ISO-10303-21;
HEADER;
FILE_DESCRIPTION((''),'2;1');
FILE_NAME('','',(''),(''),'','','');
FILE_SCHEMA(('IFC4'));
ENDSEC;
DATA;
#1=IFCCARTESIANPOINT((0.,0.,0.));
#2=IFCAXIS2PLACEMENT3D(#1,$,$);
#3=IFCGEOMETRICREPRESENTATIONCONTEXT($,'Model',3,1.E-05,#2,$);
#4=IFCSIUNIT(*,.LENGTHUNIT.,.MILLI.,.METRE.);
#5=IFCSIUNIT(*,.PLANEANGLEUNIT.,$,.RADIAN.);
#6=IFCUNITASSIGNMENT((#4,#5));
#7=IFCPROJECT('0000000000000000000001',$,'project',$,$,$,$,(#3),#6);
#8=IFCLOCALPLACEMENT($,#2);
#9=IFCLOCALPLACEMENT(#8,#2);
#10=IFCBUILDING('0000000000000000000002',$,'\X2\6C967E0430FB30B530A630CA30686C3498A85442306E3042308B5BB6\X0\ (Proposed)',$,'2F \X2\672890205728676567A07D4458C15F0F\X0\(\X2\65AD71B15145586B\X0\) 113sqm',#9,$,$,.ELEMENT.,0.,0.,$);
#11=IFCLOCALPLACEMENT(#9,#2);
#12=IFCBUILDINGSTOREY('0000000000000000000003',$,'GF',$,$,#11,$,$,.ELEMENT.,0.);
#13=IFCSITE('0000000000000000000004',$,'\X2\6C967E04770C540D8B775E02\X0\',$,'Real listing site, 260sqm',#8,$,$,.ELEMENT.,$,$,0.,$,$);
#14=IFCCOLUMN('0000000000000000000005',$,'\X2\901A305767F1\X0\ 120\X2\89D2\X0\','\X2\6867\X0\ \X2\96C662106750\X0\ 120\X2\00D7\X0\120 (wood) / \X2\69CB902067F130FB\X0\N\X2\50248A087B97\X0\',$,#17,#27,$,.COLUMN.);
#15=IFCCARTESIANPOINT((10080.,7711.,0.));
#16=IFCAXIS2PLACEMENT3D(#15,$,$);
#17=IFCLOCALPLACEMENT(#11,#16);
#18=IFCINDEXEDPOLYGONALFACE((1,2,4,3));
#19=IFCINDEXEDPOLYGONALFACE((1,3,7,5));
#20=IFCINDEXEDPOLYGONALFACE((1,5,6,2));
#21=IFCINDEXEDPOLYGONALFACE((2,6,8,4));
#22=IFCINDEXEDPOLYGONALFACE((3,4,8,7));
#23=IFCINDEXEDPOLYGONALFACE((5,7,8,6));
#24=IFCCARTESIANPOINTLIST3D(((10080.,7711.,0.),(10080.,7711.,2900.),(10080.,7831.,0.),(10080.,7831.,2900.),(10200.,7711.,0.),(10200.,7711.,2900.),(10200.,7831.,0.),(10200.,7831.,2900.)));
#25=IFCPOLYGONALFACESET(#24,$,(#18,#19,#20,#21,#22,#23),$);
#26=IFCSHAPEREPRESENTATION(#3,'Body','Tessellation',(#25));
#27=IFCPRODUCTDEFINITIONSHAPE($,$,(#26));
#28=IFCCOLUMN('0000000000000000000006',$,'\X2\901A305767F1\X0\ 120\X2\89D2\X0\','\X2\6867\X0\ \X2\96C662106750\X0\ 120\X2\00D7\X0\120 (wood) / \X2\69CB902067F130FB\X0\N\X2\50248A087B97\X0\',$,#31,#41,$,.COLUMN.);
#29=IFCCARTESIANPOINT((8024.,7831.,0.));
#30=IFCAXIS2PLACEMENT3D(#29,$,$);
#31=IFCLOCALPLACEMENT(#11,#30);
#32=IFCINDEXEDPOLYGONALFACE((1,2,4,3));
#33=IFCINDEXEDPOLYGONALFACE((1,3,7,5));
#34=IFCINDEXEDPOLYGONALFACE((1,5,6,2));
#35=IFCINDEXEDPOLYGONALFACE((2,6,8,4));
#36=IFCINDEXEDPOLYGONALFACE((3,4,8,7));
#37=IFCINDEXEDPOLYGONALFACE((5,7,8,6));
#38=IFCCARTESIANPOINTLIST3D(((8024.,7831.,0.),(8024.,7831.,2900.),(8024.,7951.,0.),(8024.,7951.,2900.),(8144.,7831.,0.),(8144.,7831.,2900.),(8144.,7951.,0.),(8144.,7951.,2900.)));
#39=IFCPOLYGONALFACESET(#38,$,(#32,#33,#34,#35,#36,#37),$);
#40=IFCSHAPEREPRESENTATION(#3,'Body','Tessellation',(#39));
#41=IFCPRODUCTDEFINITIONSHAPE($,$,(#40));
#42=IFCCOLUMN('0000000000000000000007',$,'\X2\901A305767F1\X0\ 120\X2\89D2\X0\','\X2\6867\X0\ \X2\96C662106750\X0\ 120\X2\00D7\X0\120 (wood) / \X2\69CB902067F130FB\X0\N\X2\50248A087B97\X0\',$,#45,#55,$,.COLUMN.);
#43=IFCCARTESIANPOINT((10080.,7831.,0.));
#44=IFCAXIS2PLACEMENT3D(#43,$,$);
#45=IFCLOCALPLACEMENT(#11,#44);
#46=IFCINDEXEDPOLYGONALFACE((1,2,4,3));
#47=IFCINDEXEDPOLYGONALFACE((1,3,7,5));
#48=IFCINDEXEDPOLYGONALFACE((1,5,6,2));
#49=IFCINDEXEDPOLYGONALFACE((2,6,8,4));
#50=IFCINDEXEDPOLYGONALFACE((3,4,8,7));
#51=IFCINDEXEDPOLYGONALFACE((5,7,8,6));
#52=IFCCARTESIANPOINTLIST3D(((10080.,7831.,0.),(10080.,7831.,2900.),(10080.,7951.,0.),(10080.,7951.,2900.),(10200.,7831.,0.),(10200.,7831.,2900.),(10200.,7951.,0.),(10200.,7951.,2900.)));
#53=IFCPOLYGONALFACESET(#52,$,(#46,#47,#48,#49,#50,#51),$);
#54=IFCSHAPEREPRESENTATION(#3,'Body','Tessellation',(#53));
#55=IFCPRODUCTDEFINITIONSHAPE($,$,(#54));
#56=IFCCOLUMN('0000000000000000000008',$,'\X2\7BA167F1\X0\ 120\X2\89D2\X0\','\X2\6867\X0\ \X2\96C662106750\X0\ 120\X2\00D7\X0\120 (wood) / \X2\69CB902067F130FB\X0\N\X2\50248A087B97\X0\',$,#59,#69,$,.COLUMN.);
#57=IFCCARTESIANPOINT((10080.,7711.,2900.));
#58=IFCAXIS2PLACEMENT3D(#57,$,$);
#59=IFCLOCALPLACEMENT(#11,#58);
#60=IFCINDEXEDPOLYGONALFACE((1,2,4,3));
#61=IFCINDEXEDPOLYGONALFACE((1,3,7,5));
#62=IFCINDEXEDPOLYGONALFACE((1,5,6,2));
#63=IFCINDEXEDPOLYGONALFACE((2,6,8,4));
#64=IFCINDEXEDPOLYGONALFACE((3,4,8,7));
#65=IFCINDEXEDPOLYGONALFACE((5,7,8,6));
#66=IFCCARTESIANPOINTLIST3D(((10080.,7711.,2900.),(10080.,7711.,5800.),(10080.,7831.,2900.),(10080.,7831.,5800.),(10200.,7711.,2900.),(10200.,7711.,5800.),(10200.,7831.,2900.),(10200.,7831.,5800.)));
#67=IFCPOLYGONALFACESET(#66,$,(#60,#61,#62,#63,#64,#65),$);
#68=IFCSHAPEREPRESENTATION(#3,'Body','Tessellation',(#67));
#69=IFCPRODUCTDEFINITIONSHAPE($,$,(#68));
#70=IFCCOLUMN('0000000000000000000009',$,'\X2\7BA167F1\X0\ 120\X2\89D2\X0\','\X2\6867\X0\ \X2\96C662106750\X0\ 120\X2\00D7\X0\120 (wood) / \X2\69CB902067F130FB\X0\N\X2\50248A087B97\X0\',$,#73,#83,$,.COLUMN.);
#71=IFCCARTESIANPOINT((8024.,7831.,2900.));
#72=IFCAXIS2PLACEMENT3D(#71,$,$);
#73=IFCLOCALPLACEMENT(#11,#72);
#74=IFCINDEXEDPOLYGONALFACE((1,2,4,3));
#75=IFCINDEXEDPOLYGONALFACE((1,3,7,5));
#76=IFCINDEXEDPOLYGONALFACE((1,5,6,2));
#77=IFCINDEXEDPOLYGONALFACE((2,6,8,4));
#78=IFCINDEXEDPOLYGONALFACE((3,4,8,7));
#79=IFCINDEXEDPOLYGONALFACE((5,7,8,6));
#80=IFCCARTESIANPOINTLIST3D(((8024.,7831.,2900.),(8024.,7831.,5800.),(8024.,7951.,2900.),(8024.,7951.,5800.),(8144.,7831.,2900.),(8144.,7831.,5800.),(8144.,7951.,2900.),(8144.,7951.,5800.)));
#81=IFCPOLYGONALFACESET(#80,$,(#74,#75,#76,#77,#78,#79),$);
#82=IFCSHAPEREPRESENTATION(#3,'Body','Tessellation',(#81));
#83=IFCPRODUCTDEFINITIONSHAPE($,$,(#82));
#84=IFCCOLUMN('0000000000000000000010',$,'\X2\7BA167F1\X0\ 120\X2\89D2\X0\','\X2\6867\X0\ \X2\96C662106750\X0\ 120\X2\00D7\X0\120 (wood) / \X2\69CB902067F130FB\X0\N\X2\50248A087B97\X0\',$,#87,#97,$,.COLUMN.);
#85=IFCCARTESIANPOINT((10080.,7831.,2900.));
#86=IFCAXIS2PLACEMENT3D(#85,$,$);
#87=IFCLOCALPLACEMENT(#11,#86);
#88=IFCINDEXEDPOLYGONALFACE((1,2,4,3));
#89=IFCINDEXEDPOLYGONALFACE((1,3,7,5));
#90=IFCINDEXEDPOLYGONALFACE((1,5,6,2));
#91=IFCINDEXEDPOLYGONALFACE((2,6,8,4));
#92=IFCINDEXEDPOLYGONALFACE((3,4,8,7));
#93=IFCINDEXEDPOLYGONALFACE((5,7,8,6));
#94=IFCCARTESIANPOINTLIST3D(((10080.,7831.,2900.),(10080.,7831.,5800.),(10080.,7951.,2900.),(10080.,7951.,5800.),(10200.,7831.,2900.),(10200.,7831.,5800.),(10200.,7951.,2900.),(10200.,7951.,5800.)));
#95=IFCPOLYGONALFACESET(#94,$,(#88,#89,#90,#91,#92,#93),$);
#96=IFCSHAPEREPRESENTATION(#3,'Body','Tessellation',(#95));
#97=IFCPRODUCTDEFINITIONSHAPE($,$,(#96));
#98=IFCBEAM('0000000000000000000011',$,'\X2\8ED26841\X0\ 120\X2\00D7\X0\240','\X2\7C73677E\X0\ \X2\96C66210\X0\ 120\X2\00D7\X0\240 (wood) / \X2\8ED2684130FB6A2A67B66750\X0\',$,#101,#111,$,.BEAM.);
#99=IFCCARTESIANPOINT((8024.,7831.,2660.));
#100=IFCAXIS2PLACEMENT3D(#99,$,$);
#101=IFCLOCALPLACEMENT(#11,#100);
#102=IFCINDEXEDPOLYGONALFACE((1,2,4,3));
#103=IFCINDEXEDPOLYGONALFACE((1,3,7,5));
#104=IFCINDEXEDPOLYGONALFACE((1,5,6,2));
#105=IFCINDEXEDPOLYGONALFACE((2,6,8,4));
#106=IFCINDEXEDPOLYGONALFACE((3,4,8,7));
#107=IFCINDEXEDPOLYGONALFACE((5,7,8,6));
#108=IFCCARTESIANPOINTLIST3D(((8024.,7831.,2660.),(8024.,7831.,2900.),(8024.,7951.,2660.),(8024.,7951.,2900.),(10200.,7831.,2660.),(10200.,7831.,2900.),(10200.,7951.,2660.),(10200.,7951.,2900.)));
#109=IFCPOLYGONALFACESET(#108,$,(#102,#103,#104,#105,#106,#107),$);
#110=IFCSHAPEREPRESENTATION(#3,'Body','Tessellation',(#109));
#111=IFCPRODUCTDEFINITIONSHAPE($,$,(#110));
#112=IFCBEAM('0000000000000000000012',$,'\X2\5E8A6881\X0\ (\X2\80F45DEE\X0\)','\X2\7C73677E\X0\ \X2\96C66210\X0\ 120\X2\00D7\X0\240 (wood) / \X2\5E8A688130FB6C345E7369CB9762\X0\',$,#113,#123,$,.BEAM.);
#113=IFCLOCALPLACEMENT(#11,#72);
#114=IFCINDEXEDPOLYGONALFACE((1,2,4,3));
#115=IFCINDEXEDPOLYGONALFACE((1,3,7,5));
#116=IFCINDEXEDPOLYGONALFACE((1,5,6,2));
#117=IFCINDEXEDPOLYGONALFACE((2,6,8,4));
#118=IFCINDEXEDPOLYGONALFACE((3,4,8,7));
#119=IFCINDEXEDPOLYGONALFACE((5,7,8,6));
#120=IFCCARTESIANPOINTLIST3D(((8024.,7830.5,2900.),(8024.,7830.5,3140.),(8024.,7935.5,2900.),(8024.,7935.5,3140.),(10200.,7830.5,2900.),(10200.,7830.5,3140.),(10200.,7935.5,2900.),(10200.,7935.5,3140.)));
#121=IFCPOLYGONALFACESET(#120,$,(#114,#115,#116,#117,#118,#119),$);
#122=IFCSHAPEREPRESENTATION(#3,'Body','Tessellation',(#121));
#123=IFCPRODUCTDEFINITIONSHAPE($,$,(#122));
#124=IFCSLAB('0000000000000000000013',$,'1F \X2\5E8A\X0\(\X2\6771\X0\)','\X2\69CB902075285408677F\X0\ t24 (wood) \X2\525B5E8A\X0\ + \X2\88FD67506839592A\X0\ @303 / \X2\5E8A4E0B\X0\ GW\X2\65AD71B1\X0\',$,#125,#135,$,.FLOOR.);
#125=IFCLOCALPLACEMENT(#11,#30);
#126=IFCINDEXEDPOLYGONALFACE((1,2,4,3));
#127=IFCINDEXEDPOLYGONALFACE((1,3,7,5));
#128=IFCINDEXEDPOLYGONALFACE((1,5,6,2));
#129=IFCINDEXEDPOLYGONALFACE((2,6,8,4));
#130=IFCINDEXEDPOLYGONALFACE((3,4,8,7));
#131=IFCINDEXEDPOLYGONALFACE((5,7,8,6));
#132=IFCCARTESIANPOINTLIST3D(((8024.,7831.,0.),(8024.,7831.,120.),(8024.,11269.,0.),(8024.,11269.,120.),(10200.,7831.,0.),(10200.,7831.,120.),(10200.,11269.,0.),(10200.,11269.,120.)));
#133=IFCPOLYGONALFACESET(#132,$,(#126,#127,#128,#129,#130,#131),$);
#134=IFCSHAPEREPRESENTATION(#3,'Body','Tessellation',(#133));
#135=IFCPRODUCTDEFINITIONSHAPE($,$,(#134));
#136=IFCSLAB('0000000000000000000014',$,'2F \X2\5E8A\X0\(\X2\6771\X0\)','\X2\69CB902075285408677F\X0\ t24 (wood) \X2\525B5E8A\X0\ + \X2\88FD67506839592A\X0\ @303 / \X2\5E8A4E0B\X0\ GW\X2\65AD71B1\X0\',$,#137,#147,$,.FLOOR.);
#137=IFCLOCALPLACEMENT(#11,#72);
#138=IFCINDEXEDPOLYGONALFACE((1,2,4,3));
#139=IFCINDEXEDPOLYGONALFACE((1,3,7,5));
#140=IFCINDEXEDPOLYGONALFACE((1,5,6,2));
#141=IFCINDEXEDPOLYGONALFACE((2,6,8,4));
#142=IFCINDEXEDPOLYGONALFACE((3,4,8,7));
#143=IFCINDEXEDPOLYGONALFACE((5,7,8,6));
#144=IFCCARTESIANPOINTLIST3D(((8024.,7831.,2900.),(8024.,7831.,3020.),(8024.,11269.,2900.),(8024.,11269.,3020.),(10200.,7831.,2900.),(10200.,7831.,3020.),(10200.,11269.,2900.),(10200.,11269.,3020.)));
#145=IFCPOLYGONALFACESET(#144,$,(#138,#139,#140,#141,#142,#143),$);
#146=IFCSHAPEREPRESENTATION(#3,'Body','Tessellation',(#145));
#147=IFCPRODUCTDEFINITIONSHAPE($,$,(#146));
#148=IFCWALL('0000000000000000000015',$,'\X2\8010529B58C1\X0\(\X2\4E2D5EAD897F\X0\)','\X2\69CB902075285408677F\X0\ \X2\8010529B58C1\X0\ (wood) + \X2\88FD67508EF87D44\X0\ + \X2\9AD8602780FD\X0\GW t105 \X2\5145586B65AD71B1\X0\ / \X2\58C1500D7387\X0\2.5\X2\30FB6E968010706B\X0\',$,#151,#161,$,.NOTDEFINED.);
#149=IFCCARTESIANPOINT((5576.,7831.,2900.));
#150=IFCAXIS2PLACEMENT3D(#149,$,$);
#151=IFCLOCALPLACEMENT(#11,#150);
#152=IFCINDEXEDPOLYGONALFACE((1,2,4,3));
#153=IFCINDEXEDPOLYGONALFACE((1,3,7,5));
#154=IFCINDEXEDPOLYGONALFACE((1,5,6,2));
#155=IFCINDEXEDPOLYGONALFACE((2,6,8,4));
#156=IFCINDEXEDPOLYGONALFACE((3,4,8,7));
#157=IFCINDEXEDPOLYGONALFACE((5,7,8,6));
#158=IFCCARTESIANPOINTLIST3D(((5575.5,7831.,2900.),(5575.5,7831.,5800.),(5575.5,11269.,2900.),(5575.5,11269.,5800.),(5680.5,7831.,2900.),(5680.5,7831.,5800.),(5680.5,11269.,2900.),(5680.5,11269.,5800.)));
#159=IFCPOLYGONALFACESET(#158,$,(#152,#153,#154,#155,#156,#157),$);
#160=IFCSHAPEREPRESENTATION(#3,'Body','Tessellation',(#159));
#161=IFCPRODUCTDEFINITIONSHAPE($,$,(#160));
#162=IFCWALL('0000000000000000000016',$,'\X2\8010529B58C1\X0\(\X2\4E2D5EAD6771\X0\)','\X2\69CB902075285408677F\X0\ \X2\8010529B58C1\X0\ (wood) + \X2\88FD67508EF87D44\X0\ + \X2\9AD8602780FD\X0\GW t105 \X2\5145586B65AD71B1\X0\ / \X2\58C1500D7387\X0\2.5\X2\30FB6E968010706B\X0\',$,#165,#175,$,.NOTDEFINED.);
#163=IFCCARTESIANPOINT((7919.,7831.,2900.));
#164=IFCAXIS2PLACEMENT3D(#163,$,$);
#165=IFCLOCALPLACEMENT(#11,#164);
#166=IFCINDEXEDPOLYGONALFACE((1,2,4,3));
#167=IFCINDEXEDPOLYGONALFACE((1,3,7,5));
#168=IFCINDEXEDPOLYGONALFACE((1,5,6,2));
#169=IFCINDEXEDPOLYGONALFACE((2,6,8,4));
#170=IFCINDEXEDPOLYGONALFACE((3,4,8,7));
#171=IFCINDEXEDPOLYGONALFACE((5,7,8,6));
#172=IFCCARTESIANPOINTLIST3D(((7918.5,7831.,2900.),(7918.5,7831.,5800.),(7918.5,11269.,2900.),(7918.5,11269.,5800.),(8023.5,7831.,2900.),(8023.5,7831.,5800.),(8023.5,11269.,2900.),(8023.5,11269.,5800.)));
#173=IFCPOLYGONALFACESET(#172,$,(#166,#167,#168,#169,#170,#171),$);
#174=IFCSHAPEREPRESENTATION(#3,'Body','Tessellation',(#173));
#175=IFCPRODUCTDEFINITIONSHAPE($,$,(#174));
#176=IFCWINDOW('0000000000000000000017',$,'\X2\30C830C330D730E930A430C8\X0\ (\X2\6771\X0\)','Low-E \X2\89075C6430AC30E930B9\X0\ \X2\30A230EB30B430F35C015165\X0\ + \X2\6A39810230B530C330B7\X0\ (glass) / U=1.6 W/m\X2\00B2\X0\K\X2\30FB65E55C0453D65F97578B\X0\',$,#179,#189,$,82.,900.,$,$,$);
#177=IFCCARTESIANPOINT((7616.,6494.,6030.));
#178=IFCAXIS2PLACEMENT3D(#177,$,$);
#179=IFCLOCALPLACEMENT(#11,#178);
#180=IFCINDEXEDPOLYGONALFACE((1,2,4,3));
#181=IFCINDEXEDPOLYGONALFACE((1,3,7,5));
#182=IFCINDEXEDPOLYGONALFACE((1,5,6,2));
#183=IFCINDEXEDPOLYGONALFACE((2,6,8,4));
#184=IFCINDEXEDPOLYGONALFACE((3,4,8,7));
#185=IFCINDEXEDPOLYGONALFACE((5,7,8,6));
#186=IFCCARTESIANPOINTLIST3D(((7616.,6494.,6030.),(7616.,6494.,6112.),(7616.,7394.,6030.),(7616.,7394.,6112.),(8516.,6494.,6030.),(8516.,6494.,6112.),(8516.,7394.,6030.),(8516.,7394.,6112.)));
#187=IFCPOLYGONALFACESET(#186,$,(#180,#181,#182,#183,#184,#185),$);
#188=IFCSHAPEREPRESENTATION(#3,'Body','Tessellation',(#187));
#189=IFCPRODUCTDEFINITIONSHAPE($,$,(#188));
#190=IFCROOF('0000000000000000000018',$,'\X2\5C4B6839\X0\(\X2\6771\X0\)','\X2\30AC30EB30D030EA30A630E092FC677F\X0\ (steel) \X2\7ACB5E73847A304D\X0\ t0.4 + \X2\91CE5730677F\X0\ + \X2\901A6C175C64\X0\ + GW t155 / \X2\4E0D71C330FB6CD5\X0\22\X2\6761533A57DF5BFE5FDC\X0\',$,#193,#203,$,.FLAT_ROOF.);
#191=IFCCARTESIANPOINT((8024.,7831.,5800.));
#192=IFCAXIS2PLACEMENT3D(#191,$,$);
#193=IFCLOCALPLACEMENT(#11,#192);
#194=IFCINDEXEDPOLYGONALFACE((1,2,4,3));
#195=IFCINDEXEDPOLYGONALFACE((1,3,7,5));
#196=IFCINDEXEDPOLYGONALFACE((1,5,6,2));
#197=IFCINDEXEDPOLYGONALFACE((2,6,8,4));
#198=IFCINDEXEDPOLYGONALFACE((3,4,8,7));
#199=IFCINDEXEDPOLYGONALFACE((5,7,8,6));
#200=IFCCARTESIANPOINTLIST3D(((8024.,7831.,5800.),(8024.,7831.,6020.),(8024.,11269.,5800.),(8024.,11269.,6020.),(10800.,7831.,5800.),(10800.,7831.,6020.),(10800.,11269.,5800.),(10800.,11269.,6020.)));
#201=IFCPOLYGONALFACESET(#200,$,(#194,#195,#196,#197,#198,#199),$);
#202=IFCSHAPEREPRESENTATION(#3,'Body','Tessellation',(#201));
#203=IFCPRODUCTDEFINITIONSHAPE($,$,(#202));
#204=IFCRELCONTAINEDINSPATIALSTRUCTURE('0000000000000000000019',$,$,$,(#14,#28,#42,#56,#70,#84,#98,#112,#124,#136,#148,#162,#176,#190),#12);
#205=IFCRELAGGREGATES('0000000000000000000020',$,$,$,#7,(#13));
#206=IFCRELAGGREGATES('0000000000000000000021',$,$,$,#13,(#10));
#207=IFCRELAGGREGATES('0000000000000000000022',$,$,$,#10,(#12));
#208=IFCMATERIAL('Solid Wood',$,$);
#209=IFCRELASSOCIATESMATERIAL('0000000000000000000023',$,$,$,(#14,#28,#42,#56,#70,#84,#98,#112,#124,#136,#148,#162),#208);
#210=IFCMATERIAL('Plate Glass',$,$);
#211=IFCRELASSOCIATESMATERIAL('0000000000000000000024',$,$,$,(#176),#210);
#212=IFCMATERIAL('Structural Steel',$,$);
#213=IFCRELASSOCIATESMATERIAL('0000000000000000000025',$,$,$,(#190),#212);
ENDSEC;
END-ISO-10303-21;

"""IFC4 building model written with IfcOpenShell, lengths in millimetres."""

from ifc_helpers import new_model, si_unit, frame, frame_2d, origin, place, context, project, spatial, rectangle, extrude, material, element, save


model = new_model("IFC4")

# Units and contexts
model_context = context("Model", 3, precision=1e-05, world=origin())
ifc_project = project(units=[si_unit("LENGTHUNIT", "METRE", prefix="MILLI"), si_unit("PLANEANGLEUNIT", "RADIAN")], contexts=[model_context])

# Site, building, storey
site_placement = place(None, origin())
site = spatial("IfcSite", under=ifc_project, at=site_placement, Name="沖縄県名護市", ObjectType="Real listing site, 260sqm", CompositionType="ELEMENT", RefElevation=0.0)
building_placement = place(site_placement, origin())
building = spatial("IfcBuilding", under=site, at=building_placement, Name="沖縄・サウナと水風呂のある家 (Proposed)", ObjectType="2F 木造在来枠組壁式(断熱充填) 113sqm", CompositionType="ELEMENT", ElevationOfRefHeight=0.0, ElevationOfTerrain=0.0)
storey_placement = place(building_placement, origin())
storey = spatial("IfcBuildingStorey", under=building, at=storey_placement, Name="GF", CompositionType="ELEMENT", Elevation=0.0)

# Columns
ifc_material_1 = material(Name="Solid Wood")
column_1_placement = place(storey_placement, frame((10080.0, 7711.0, 0.0)))
element("IfcColumn", 1, at=column_1_placement, inside=storey, material=ifc_material_1, Name="通し柱 120角", Description="桧 集成材 120×120 (wood) / 構造柱・N値計算", PredefinedType="COLUMN", context=model_context, shape_type="SweptSolid", body=[
    extrude(rectangle(XDim=120.0, YDim=120.0, at=frame_2d((60.0, 60.0))), frame((10080.0, 7711.0, 0.0)), (0.0, 0.0, 1.0), 2900.0),
])
column_2_placement = place(storey_placement, frame((8024.0, 7831.0, 0.0)))
element("IfcColumn", 2, at=column_2_placement, inside=storey, material=ifc_material_1, Name="通し柱 120角", Description="桧 集成材 120×120 (wood) / 構造柱・N値計算", PredefinedType="COLUMN", context=model_context, shape_type="SweptSolid", body=[
    extrude(rectangle(XDim=120.0, YDim=120.0, at=frame_2d((60.0, 60.0))), frame((8024.0, 7831.0, 0.0)), (0.0, 0.0, 1.0), 2900.0),
])
column_3_placement = place(storey_placement, frame((10080.0, 7831.0, 0.0)))
element("IfcColumn", 3, at=column_3_placement, inside=storey, material=ifc_material_1, Name="通し柱 120角", Description="桧 集成材 120×120 (wood) / 構造柱・N値計算", PredefinedType="COLUMN", context=model_context, shape_type="SweptSolid", body=[
    extrude(rectangle(XDim=120.0, YDim=120.0, at=frame_2d((60.0, 60.0))), frame((10080.0, 7831.0, 0.0)), (0.0, 0.0, 1.0), 2900.0),
])
column_4_placement = place(storey_placement, frame((10080.0, 7711.0, 2900.0)))
element("IfcColumn", 4, at=column_4_placement, inside=storey, material=ifc_material_1, Name="管柱 120角", Description="桧 集成材 120×120 (wood) / 構造柱・N値計算", PredefinedType="COLUMN", context=model_context, shape_type="SweptSolid", body=[
    extrude(rectangle(XDim=120.0, YDim=120.0, at=frame_2d((60.0, 60.0))), frame((10080.0, 7711.0, 2900.0)), (0.0, 0.0, 1.0), 2900.0),
])
column_5_placement = place(storey_placement, frame((8024.0, 7831.0, 2900.0)))
element("IfcColumn", 5, at=column_5_placement, inside=storey, material=ifc_material_1, Name="管柱 120角", Description="桧 集成材 120×120 (wood) / 構造柱・N値計算", PredefinedType="COLUMN", context=model_context, shape_type="SweptSolid", body=[
    extrude(rectangle(XDim=120.0, YDim=120.0, at=frame_2d((60.0, 60.0))), frame((8024.0, 7831.0, 2900.0)), (0.0, 0.0, 1.0), 2900.0),
])
column_6_placement = place(storey_placement, frame((10080.0, 7831.0, 2900.0)))
element("IfcColumn", 6, at=column_6_placement, inside=storey, material=ifc_material_1, Name="管柱 120角", Description="桧 集成材 120×120 (wood) / 構造柱・N値計算", PredefinedType="COLUMN", context=model_context, shape_type="SweptSolid", body=[
    extrude(rectangle(XDim=120.0, YDim=120.0, at=frame_2d((60.0, 60.0))), frame((10080.0, 7831.0, 2900.0)), (0.0, 0.0, 1.0), 2900.0),
])

# Beams
beam_1_placement = place(storey_placement, frame((8024.0, 7831.0, 2660.0)))
element("IfcBeam", 7, at=beam_1_placement, inside=storey, material=ifc_material_1, Name="軒桁 120×240", Description="米松 集成 120×240 (wood) / 軒桁・横架材", PredefinedType="BEAM", context=model_context, shape_type="SweptSolid", body=[
    extrude(rectangle(XDim=2176.0, YDim=120.0, at=frame_2d((1088.0, 60.0))), frame((8024.0, 7831.0, 2660.0)), (0.0, 0.0, 1.0), 240.0),
])
beam_2_placement = place(storey_placement, frame((8024.0, 7831.0, 2900.0)))
element("IfcBeam", 8, at=beam_2_placement, inside=storey, material=ifc_material_1, Name="床梁 (胴差)", Description="米松 集成 120×240 (wood) / 床梁・水平構面", PredefinedType="BEAM", context=model_context, shape_type="SweptSolid", body=[
    extrude(rectangle(XDim=2176.0, YDim=105.0, at=frame_2d((1088.0, 52.0))), frame((8024.0, 7831.0, 2900.0)), (0.0, 0.0, 1.0), 240.0),
])

# Slabs
slab_1_placement = place(storey_placement, frame((8024.0, 7831.0, 0.0)))
element("IfcSlab", 9, at=slab_1_placement, inside=storey, material=ifc_material_1, Name="1F 床(東)", Description="構造用合板 t24 (wood) 剛床 + 製材根太 @303 / 床下 GW断熱", PredefinedType="FLOOR", context=model_context, shape_type="SweptSolid", body=[
    extrude(rectangle(XDim=2176.0, YDim=3438.0, at=frame_2d((1088.0, 1719.0))), frame((8024.0, 7831.0, 0.0)), (0.0, 0.0, 1.0), 120.0),
])
slab_2_placement = place(storey_placement, frame((8024.0, 7831.0, 2900.0)))
element("IfcSlab", 10, at=slab_2_placement, inside=storey, material=ifc_material_1, Name="2F 床(東)", Description="構造用合板 t24 (wood) 剛床 + 製材根太 @303 / 床下 GW断熱", PredefinedType="FLOOR", context=model_context, shape_type="SweptSolid", body=[
    extrude(rectangle(XDim=2176.0, YDim=3438.0, at=frame_2d((1088.0, 1719.0))), frame((8024.0, 7831.0, 2900.0)), (0.0, 0.0, 1.0), 120.0),
])

# Walls
wall_1_placement = place(storey_placement, frame((5576.0, 7831.0, 2900.0)))
element("IfcWall", 11, at=wall_1_placement, inside=storey, material=ifc_material_1, Name="耐力壁(中庭西)", Description="構造用合板 耐力壁 (wood) + 製材軸組 + 高性能GW t105 充填断熱 / 壁倍率2.5・準耐火", PredefinedType="NOTDEFINED", context=model_context, shape_type="SweptSolid", body=[
    extrude(rectangle(XDim=105.0, YDim=3438.0, at=frame_2d((52.0, 1719.0))), frame((5576.0, 7831.0, 2900.0)), (0.0, 0.0, 1.0), 2900.0),
])
wall_2_placement = place(storey_placement, frame((7919.0, 7831.0, 2900.0)))
element("IfcWall", 12, at=wall_2_placement, inside=storey, material=ifc_material_1, Name="耐力壁(中庭東)", Description="構造用合板 耐力壁 (wood) + 製材軸組 + 高性能GW t105 充填断熱 / 壁倍率2.5・準耐火", PredefinedType="NOTDEFINED", context=model_context, shape_type="SweptSolid", body=[
    extrude(rectangle(XDim=105.0, YDim=3438.0, at=frame_2d((52.0, 1719.0))), frame((7919.0, 7831.0, 2900.0)), (0.0, 0.0, 1.0), 2900.0),
])

# Window
ifc_material_2 = material(Name="Plate Glass")
window_placement = place(storey_placement, frame((7616.0, 6494.0, 6030.0)))
element("IfcWindow", 13, at=window_placement, inside=storey, material=ifc_material_2, Name="トップライト (東)", Description="Low-E 複層ガラス アルゴン封入 + 樹脂サッシ (glass) / U=1.6 W/m²K・日射取得型", OverallHeight=82.0, OverallWidth=900.0, context=model_context, shape_type="SweptSolid", body=[
    extrude(rectangle(XDim=900.0, YDim=900.0, at=frame_2d((450.0, 450.0))), frame((7616.0, 6494.0, 6030.0)), (0.0, 0.0, 1.0), 82.0),
])

# Roof
ifc_material_3 = material(Name="Structural Steel")
for number, where, name in (
    (14, (8024.0, 7831.0, 5800.0), "屋根(東)"),
):
    element("IfcRoof", number, at=place(storey_placement, frame(where)), inside=storey, material=ifc_material_3, Name=name, Description="ガルバリウム鋼板 (steel) 立平葺き t0.4 + 野地板 + 通気層 + GW t155 / 不燃・法22条区域対応", PredefinedType="FLAT_ROOF", context=model_context, shape_type="SweptSolid", body=[
        extrude(rectangle(XDim=2776.0, YDim=3438.0, at=frame_2d((1388.0, 1719.0))), frame((8024.0, 7831.0, 5800.0)), (0.0, 0.0, 1.0), 220.0),
    ])

save(model, "model.ifc")
